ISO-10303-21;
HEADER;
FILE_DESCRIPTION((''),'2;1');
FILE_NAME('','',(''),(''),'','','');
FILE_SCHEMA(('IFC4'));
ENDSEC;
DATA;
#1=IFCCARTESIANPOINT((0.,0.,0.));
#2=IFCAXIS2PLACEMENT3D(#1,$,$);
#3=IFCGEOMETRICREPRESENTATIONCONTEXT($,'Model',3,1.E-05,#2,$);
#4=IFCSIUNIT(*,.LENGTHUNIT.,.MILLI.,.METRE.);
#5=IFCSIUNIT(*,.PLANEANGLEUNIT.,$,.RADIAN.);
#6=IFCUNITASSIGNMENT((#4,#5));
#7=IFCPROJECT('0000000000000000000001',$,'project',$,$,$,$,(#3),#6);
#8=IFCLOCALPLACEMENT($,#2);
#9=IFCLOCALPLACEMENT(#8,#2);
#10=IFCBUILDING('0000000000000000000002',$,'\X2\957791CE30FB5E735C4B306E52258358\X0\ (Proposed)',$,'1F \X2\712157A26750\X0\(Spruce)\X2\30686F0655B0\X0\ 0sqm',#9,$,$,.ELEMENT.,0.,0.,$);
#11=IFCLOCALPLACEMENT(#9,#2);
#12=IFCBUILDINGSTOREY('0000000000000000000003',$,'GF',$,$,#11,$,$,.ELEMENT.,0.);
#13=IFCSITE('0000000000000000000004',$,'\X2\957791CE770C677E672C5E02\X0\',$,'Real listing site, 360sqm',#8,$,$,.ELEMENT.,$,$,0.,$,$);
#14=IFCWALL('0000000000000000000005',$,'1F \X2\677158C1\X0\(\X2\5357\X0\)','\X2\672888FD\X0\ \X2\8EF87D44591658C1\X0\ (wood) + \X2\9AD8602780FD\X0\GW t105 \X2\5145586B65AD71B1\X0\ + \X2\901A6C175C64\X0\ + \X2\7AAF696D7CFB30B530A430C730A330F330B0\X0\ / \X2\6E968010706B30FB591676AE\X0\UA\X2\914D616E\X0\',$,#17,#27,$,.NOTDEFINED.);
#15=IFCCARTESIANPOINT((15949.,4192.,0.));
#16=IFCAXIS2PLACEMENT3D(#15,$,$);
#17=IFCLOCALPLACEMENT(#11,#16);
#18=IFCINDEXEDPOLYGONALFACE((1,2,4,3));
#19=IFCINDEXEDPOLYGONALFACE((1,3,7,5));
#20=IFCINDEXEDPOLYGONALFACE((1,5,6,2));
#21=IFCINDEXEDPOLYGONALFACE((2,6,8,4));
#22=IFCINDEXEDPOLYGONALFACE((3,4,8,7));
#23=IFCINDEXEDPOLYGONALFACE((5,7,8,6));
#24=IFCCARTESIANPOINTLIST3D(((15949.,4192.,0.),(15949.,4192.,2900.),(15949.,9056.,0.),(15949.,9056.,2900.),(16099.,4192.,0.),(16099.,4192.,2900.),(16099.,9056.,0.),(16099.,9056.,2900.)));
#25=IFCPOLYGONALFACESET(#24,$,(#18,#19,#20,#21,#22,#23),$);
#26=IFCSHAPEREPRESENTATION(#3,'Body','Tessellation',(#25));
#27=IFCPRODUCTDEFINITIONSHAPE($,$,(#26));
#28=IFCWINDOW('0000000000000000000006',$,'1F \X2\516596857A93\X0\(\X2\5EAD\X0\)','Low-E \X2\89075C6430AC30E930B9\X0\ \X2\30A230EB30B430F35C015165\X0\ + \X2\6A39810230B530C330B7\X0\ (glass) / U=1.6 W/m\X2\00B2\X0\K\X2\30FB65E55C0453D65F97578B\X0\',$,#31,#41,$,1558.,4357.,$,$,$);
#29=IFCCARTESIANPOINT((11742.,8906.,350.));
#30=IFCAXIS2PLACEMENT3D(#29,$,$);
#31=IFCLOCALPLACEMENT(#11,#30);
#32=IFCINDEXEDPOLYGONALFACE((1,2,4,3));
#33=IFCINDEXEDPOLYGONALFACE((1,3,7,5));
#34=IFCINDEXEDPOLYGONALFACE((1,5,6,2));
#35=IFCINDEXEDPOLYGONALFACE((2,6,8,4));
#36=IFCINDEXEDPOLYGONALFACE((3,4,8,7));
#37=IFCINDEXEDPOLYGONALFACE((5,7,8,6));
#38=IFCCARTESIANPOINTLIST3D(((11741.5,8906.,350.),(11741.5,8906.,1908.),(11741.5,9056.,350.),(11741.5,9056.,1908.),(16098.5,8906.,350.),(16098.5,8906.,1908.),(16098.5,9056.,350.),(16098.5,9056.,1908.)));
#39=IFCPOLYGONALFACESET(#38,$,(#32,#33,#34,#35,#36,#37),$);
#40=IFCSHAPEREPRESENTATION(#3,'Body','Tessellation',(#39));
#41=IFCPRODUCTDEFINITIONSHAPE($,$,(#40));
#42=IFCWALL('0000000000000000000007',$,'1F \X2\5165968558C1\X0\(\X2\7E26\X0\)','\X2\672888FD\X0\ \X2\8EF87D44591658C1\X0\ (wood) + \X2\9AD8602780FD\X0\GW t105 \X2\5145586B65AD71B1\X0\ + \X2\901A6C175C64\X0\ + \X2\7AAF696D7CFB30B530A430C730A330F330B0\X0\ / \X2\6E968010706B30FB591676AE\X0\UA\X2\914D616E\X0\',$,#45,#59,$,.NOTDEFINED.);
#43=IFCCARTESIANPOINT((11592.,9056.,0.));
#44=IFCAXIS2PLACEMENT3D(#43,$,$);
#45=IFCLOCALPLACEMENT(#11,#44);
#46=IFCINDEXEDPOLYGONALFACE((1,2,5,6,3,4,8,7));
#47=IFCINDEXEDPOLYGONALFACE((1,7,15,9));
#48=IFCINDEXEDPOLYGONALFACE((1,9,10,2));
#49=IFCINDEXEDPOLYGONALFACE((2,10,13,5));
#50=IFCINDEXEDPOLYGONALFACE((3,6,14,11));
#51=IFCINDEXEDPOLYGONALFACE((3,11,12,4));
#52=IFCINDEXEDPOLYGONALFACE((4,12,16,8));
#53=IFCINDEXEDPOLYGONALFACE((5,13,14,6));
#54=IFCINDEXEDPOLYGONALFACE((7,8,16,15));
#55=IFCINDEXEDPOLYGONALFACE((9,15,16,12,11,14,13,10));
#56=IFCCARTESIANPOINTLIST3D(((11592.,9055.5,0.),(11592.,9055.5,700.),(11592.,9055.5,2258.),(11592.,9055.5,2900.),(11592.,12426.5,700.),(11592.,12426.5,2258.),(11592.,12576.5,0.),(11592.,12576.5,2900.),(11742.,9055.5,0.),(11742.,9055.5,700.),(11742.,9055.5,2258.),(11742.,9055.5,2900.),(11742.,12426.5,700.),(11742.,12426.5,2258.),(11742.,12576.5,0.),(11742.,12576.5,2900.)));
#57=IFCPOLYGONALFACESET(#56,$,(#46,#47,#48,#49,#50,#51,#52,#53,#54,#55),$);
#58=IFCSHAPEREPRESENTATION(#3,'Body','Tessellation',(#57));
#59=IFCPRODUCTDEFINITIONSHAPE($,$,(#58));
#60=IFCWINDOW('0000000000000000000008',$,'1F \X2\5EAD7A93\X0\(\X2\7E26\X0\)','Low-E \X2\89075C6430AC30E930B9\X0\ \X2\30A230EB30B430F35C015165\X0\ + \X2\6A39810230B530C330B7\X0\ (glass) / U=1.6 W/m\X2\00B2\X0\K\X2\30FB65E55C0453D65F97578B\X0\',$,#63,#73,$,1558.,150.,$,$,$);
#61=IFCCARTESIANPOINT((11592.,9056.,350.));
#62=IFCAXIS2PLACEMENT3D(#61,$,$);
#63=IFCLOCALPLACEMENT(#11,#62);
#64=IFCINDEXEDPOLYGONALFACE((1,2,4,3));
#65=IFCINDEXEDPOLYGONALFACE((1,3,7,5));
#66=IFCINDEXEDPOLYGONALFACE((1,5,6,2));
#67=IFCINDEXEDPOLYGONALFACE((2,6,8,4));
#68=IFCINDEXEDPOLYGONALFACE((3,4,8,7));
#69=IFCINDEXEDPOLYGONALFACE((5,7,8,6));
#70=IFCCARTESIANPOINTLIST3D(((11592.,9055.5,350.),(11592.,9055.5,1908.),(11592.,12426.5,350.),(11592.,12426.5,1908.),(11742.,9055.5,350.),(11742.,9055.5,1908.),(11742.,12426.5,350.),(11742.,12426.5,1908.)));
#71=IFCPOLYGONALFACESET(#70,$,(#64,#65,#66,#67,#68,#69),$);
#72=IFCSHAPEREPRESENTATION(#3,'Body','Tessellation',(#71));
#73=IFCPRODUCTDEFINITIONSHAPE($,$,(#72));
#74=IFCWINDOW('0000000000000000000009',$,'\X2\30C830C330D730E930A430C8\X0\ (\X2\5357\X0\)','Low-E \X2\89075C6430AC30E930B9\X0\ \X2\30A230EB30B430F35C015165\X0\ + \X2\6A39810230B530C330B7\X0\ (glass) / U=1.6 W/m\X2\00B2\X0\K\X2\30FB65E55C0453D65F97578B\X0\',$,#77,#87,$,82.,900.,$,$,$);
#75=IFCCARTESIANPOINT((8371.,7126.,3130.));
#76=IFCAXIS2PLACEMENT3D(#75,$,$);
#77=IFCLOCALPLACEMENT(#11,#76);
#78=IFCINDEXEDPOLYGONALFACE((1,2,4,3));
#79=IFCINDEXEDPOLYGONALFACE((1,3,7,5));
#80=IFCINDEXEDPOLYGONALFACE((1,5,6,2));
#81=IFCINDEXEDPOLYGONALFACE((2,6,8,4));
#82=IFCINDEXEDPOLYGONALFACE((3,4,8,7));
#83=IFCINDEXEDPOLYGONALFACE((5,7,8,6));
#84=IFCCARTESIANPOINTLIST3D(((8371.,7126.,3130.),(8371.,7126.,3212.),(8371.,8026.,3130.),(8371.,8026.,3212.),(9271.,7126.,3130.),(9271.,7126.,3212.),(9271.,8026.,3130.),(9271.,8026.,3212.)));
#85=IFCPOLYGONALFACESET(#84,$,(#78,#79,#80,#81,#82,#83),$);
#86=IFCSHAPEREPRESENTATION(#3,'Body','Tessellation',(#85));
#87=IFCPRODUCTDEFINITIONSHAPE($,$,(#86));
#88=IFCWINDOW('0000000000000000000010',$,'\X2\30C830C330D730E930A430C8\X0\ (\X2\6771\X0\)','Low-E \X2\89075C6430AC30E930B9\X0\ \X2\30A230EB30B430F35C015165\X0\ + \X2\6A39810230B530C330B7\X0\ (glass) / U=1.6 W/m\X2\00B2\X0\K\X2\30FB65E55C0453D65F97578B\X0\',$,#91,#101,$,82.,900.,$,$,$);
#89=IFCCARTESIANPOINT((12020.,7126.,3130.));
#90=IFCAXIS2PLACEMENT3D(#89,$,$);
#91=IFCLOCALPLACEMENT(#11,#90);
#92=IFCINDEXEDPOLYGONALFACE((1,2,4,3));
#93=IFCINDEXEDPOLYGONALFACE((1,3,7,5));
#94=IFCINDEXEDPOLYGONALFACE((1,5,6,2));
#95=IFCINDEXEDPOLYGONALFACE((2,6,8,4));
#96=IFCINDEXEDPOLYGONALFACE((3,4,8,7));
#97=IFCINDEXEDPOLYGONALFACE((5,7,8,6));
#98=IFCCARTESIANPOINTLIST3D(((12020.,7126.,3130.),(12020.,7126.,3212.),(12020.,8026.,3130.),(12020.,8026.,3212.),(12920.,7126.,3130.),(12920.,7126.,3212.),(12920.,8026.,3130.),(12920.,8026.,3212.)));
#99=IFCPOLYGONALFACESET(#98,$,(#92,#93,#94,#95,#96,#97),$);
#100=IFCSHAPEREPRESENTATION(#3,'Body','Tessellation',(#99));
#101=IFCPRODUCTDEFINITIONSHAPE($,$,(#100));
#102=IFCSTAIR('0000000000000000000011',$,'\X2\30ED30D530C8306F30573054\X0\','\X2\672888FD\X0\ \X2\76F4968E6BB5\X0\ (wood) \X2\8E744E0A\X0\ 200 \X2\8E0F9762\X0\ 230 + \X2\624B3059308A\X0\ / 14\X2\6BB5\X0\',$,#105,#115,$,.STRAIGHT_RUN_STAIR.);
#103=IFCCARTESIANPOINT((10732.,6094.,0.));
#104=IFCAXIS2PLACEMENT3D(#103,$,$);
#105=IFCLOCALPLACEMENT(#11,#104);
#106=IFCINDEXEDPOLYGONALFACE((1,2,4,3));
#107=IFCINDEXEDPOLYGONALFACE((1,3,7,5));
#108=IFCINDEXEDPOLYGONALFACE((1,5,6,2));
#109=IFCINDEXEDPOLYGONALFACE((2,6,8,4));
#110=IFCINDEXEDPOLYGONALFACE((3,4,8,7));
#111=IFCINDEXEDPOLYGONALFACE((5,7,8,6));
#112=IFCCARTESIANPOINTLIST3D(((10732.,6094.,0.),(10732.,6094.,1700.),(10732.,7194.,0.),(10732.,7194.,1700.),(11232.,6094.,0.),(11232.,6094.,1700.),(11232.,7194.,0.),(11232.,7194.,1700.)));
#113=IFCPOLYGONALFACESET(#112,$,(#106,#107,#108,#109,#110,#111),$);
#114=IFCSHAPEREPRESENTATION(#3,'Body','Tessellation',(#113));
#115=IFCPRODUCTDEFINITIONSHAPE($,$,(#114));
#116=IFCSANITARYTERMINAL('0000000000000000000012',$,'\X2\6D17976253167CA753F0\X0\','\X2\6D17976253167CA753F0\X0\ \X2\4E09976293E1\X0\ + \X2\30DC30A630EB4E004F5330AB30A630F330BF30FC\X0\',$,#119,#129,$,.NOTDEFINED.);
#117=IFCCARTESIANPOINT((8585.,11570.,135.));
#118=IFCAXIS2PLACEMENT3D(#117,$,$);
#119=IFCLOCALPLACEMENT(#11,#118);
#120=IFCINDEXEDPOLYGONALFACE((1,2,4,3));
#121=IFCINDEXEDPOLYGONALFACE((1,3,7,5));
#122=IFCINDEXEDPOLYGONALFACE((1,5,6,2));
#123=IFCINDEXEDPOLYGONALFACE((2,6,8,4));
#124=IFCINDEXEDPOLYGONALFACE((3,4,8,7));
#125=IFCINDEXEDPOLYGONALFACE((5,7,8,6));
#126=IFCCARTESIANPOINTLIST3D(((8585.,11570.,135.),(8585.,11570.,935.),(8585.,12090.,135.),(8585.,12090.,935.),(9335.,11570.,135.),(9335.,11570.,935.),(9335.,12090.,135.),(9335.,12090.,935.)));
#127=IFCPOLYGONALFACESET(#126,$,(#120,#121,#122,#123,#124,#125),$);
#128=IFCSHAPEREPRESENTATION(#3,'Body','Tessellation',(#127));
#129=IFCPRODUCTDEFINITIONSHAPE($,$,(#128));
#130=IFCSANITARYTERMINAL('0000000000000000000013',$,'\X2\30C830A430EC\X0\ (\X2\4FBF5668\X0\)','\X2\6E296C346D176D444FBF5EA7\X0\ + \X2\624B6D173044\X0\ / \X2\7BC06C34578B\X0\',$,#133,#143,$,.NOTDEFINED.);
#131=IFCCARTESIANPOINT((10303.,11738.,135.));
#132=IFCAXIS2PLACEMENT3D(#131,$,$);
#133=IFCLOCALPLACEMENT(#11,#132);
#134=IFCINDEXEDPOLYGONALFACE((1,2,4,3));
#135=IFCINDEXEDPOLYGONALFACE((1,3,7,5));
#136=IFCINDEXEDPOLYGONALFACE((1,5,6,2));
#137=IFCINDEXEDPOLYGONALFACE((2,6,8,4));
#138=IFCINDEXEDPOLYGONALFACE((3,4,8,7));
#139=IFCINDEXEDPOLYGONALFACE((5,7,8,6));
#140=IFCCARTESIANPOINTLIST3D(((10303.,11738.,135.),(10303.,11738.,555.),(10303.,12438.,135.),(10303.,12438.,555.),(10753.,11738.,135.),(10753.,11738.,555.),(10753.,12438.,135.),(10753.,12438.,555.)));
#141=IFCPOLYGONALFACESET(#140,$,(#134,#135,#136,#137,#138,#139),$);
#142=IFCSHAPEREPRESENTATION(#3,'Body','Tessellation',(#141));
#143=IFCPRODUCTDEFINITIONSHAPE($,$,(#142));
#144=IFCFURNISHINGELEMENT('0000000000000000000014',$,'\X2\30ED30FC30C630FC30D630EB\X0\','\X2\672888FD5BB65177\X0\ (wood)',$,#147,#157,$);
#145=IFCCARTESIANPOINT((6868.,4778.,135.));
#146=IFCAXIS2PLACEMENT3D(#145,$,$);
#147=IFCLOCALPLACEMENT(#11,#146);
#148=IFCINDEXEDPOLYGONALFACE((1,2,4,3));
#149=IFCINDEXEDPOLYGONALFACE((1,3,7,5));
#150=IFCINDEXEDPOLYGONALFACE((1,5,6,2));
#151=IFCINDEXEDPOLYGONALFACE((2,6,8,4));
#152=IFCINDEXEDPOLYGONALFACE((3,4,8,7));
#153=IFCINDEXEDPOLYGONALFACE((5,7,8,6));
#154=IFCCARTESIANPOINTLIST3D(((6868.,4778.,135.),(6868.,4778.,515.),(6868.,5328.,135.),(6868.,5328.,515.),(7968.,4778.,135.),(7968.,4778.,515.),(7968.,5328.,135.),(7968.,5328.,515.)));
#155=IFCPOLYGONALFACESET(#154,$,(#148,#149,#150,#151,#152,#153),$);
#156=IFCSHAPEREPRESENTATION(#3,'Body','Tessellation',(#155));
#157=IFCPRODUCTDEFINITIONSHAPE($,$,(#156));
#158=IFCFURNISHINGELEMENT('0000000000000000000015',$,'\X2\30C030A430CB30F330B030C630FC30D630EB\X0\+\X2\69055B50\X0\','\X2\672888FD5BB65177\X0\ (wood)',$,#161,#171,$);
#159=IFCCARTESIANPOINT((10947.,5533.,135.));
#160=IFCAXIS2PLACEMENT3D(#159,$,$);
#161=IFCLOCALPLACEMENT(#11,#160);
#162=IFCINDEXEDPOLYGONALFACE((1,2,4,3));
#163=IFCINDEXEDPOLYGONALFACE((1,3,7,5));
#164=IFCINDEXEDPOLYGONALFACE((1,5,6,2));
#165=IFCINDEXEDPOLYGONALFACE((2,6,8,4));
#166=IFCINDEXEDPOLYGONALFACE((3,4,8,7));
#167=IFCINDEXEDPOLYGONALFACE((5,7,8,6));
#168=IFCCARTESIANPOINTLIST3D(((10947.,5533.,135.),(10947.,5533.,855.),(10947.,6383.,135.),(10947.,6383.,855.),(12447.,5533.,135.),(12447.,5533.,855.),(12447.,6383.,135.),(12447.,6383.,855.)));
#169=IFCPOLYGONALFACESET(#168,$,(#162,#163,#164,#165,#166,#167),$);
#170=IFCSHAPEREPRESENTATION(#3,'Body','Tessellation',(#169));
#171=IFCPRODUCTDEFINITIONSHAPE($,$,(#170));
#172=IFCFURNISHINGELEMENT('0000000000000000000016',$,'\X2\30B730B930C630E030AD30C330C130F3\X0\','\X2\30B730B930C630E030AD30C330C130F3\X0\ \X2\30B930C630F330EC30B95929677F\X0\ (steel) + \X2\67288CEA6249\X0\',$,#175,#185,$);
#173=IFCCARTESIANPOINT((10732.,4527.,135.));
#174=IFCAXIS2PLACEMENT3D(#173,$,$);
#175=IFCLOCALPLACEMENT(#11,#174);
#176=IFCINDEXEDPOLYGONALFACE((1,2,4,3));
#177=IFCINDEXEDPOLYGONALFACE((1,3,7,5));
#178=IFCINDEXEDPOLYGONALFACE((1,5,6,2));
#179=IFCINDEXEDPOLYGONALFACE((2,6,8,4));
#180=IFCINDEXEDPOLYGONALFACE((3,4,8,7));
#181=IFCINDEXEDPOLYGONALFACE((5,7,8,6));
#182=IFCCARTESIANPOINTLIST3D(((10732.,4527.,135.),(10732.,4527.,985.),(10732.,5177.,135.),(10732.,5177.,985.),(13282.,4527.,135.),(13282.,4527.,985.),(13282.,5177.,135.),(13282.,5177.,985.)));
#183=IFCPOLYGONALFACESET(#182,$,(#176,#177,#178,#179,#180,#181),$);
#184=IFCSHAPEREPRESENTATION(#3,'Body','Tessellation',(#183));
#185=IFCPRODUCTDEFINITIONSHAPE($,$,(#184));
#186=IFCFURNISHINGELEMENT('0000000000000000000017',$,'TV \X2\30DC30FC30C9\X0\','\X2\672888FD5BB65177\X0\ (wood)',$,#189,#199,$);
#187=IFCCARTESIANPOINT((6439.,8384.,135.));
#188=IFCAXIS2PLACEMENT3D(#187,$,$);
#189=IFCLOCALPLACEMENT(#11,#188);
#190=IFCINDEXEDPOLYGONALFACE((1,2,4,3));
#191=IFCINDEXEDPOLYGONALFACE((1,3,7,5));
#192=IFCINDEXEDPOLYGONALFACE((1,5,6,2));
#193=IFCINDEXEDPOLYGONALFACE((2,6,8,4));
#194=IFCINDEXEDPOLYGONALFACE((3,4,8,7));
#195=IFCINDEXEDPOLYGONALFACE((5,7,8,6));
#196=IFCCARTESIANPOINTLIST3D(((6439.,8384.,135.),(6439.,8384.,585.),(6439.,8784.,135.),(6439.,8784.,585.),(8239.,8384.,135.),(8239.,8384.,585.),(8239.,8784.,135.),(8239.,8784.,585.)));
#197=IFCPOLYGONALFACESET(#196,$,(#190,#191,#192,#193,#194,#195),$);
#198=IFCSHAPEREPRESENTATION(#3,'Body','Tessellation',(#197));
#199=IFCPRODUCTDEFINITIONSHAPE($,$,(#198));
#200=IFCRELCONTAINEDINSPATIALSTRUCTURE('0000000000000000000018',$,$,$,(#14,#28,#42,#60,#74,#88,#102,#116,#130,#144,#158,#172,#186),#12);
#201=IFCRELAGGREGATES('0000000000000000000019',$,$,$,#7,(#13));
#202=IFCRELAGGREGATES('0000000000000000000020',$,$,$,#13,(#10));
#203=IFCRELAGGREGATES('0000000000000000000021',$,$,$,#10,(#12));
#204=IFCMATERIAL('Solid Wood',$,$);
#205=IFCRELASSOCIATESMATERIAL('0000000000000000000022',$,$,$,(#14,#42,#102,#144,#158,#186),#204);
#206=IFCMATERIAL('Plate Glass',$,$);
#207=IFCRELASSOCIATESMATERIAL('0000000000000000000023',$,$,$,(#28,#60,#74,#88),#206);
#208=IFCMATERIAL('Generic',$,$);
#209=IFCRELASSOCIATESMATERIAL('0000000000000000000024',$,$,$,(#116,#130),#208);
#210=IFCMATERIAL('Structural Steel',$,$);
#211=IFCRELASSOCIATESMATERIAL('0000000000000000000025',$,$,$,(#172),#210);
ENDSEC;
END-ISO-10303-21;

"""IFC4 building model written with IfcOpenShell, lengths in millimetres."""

from ifc_helpers import new_model, si_unit, frame, frame_2d, origin, place, context, project, spatial, rectangle, extrude, material, element, fill, save


model = new_model("IFC4")

# Units and contexts
model_context = context("Model", 3, precision=1e-05, world=origin())
ifc_project = project(units=[si_unit("LENGTHUNIT", "METRE", prefix="MILLI"), si_unit("PLANEANGLEUNIT", "RADIAN")], contexts=[model_context])

# Site, building, storey
site_placement = place(None, origin())
site = spatial("IfcSite", under=ifc_project, at=site_placement, Name="長野県松本市", ObjectType="Real listing site, 360sqm", CompositionType="ELEMENT", RefElevation=0.0)
building_placement = place(site_placement, origin())
building = spatial("IfcBuilding", under=site, at=building_placement, Name="長野・平屋の別荘 (Proposed)", ObjectType="1F 無垢材(Spruce)と漆喰 0sqm", CompositionType="ELEMENT", ElevationOfRefHeight=0.0, ElevationOfTerrain=0.0)
storey_placement = place(building_placement, origin())
storey = spatial("IfcBuildingStorey", under=building, at=storey_placement, Name="GF", CompositionType="ELEMENT", Elevation=0.0)

# Shared definitions
ifc_material_1 = material(Name="Solid Wood")

# Wall, opening, window
wall_1_placement = place(storey_placement, frame((15949.0, 4192.0, 0.0)))
wall_1 = element("IfcWall", 1, at=wall_1_placement, inside=storey, material=ifc_material_1, Name="1F 東壁(南)", Description="木製 軸組外壁 (wood) + 高性能GW t105 充填断熱 + 通気層 + 窯業系サイディング / 準耐火・外皮UA配慮", PredefinedType="NOTDEFINED", context=model_context, shape_type="SweptSolid", body=[
    extrude(rectangle(XDim=150.0, YDim=4864.0, at=frame_2d((75.0, 2432.0))), frame((15949.0, 4192.0, 0.0)), (0.0, 0.0, 1.0), 2900.0),
])
opening_1_placement = place(storey_placement, frame((11742.0, 8906.0, 350.0)))
opening_1 = element("IfcOpeningElement", 2, at=opening_1_placement, cuts=wall_1, PredefinedType="NOTDEFINED", context=model_context, shape_type="SweptSolid", body=[
    extrude(rectangle(XDim=4357.0, YDim=150.0, at=frame_2d((2178.0, 75.0))), frame((11742.0, 8906.0, 350.0)), (0.0, 0.0, 1.0), 1558.0),
])
ifc_material_2 = material(Name="Plate Glass")
window_1_placement = place(storey_placement, frame((11742.0, 8906.0, 350.0)))
window_1 = element("IfcWindow", 3, at=window_1_placement, inside=storey, material=ifc_material_2, Name="1F 入隅窓(庭)", Description="Low-E 複層ガラス アルゴン封入 + 樹脂サッシ (glass) / U=1.6 W/m²K・日射取得型", OverallHeight=1558.0, OverallWidth=4357.0, context=model_context, shape_type="SweptSolid", body=[
    extrude(rectangle(XDim=4357.0, YDim=150.0, at=frame_2d((2178.0, 75.0))), frame((11742.0, 8906.0, 350.0)), (0.0, 0.0, 1.0), 1558.0),
])
fill(opening_1, window_1)

# Wall, opening, window
wall_2_placement = place(storey_placement, frame((11592.0, 9056.0, 0.0)))
wall_2 = element("IfcWall", 4, at=wall_2_placement, inside=storey, material=ifc_material_1, Name="1F 入隅壁(縦)", Description="木製 軸組外壁 (wood) + 高性能GW t105 充填断熱 + 通気層 + 窯業系サイディング / 準耐火・外皮UA配慮", PredefinedType="NOTDEFINED", context=model_context, shape_type="SweptSolid", body=[
    extrude(rectangle(XDim=150.0, YDim=3521.0, at=frame_2d((75.0, 1760.0))), frame((11592.0, 9056.0, 0.0)), (0.0, 0.0, 1.0), 2900.0),
])
opening_2_placement = place(storey_placement, frame((11592.0, 9056.0, 350.0)))
opening_2 = element("IfcOpeningElement", 5, at=opening_2_placement, cuts=wall_2, PredefinedType="NOTDEFINED", context=model_context, shape_type="SweptSolid", body=[
    extrude(rectangle(XDim=150.0, YDim=3371.0, at=frame_2d((75.0, 1685.0))), frame((11592.0, 9056.0, 350.0)), (0.0, 0.0, 1.0), 1558.0),
])
window_2_placement = place(storey_placement, frame((11592.0, 9056.0, 350.0)))
window_2 = element("IfcWindow", 6, at=window_2_placement, inside=storey, material=ifc_material_2, Name="1F 庭窓(縦)", Description="Low-E 複層ガラス アルゴン封入 + 樹脂サッシ (glass) / U=1.6 W/m²K・日射取得型", OverallHeight=1558.0, OverallWidth=150.0, context=model_context, shape_type="SweptSolid", body=[
    extrude(rectangle(XDim=150.0, YDim=3371.0, at=frame_2d((75.0, 1685.0))), frame((11592.0, 9056.0, 350.0)), (0.0, 0.0, 1.0), 1558.0),
])
fill(opening_2, window_2)

# Windows
window_3_placement = place(storey_placement, frame((8371.0, 7126.0, 3130.0)))
element("IfcWindow", 7, at=window_3_placement, inside=storey, material=ifc_material_2, Name="トップライト (南)", Description="Low-E 複層ガラス アルゴン封入 + 樹脂サッシ (glass) / U=1.6 W/m²K・日射取得型", OverallHeight=82.0, OverallWidth=900.0, context=model_context, shape_type="SweptSolid", body=[
    extrude(rectangle(XDim=900.0, YDim=900.0, at=frame_2d((450.0, 450.0))), frame((8371.0, 7126.0, 3130.0)), (0.0, 0.0, 1.0), 82.0),
])
window_4_placement = place(storey_placement, frame((12020.0, 7126.0, 3130.0)))
element("IfcWindow", 8, at=window_4_placement, inside=storey, material=ifc_material_2, Name="トップライト (東)", Description="Low-E 複層ガラス アルゴン封入 + 樹脂サッシ (glass) / U=1.6 W/m²K・日射取得型", OverallHeight=82.0, OverallWidth=900.0, context=model_context, shape_type="SweptSolid", body=[
    extrude(rectangle(XDim=900.0, YDim=900.0, at=frame_2d((450.0, 450.0))), frame((12020.0, 7126.0, 3130.0)), (0.0, 0.0, 1.0), 82.0),
])

# Stair
stair_placement = place(storey_placement, frame((10732.0, 6094.0, 0.0)))
element("IfcStair", 9, at=stair_placement, inside=storey, material=ifc_material_1, Name="ロフトはしご", Description="木製 直階段 (wood) 蹴上 200 踏面 230 + 手すり / 14段", PredefinedType="STRAIGHT_RUN_STAIR", context=model_context, shape_type="SweptSolid", body=[
    extrude(rectangle(XDim=500.0, YDim=1100.0, at=frame_2d((250.0, 550.0))), frame((10732.0, 6094.0, 0.0)), (0.0, 0.0, 1.0), 1700.0),
])

# Sanitary terminals
ifc_material_3 = material(Name="Generic")
sanitary_terminal_1_placement = place(storey_placement, frame((8585.0, 11570.0, 135.0)))
element("IfcSanitaryTerminal", 10, at=sanitary_terminal_1_placement, inside=storey, material=ifc_material_3, Name="洗面化粧台", Description="洗面化粧台 三面鏡 + ボウル一体カウンター", PredefinedType="NOTDEFINED", context=model_context, shape_type="SweptSolid", body=[
    extrude(rectangle(XDim=750.0, YDim=520.0, at=frame_2d((375.0, 260.0))), frame((8585.0, 11570.0, 135.0)), (0.0, 0.0, 1.0), 800.0),
])
sanitary_terminal_2_placement = place(storey_placement, frame((10303.0, 11738.0, 135.0)))
element("IfcSanitaryTerminal", 11, at=sanitary_terminal_2_placement, inside=storey, material=ifc_material_3, Name="トイレ (便器)", Description="温水洗浄便座 + 手洗い / 節水型", PredefinedType="NOTDEFINED", context=model_context, shape_type="SweptSolid", body=[
    extrude(rectangle(XDim=450.0, YDim=700.0, at=frame_2d((225.0, 350.0))), frame((10303.0, 11738.0, 135.0)), (0.0, 0.0, 1.0), 420.0),
])

# Furnishing elements
furnishing_1_placement = place(storey_placement, frame((6868.0, 4778.0, 135.0)))
element("IfcFurnishingElement", 12, at=furnishing_1_placement, inside=storey, material=ifc_material_1, Name="ローテーブル", Description="木製家具 (wood)", context=model_context, shape_type="SweptSolid", body=[
    extrude(rectangle(XDim=1100.0, YDim=550.0, at=frame_2d((550.0, 275.0))), frame((6868.0, 4778.0, 135.0)), (0.0, 0.0, 1.0), 380.0),
])
furnishing_2_placement = place(storey_placement, frame((10947.0, 5533.0, 135.0)))
element("IfcFurnishingElement", 13, at=furnishing_2_placement, inside=storey, material=ifc_material_1, Name="ダイニングテーブル+椅子", Description="木製家具 (wood)", context=model_context, shape_type="SweptSolid", body=[
    extrude(rectangle(XDim=1500.0, YDim=850.0, at=frame_2d((750.0, 425.0))), frame((10947.0, 5533.0, 135.0)), (0.0, 0.0, 1.0), 720.0),
])
ifc_material_4 = material(Name="Structural Steel")
furnishing_3_placement = place(storey_placement, frame((10732.0, 4527.0, 135.0)))
element("IfcFurnishingElement", 14, at=furnishing_3_placement, inside=storey, material=ifc_material_4, Name="システムキッチン", Description="システムキッチン ステンレス天板 (steel) + 木質扉", context=model_context, shape_type="SweptSolid", body=[
    extrude(rectangle(XDim=2550.0, YDim=650.0, at=frame_2d((1275.0, 325.0))), frame((10732.0, 4527.0, 135.0)), (0.0, 0.0, 1.0), 850.0),
])
furnishing_4_placement = place(storey_placement, frame((6439.0, 8384.0, 135.0)))
element("IfcFurnishingElement", 15, at=furnishing_4_placement, inside=storey, material=ifc_material_1, Name="TV ボード", Description="木製家具 (wood)", context=model_context, shape_type="SweptSolid", body=[
    extrude(rectangle(XDim=1800.0, YDim=400.0, at=frame_2d((900.0, 200.0))), frame((6439.0, 8384.0, 135.0)), (0.0, 0.0, 1.0), 450.0),
])

save(model, "model.ifc")
